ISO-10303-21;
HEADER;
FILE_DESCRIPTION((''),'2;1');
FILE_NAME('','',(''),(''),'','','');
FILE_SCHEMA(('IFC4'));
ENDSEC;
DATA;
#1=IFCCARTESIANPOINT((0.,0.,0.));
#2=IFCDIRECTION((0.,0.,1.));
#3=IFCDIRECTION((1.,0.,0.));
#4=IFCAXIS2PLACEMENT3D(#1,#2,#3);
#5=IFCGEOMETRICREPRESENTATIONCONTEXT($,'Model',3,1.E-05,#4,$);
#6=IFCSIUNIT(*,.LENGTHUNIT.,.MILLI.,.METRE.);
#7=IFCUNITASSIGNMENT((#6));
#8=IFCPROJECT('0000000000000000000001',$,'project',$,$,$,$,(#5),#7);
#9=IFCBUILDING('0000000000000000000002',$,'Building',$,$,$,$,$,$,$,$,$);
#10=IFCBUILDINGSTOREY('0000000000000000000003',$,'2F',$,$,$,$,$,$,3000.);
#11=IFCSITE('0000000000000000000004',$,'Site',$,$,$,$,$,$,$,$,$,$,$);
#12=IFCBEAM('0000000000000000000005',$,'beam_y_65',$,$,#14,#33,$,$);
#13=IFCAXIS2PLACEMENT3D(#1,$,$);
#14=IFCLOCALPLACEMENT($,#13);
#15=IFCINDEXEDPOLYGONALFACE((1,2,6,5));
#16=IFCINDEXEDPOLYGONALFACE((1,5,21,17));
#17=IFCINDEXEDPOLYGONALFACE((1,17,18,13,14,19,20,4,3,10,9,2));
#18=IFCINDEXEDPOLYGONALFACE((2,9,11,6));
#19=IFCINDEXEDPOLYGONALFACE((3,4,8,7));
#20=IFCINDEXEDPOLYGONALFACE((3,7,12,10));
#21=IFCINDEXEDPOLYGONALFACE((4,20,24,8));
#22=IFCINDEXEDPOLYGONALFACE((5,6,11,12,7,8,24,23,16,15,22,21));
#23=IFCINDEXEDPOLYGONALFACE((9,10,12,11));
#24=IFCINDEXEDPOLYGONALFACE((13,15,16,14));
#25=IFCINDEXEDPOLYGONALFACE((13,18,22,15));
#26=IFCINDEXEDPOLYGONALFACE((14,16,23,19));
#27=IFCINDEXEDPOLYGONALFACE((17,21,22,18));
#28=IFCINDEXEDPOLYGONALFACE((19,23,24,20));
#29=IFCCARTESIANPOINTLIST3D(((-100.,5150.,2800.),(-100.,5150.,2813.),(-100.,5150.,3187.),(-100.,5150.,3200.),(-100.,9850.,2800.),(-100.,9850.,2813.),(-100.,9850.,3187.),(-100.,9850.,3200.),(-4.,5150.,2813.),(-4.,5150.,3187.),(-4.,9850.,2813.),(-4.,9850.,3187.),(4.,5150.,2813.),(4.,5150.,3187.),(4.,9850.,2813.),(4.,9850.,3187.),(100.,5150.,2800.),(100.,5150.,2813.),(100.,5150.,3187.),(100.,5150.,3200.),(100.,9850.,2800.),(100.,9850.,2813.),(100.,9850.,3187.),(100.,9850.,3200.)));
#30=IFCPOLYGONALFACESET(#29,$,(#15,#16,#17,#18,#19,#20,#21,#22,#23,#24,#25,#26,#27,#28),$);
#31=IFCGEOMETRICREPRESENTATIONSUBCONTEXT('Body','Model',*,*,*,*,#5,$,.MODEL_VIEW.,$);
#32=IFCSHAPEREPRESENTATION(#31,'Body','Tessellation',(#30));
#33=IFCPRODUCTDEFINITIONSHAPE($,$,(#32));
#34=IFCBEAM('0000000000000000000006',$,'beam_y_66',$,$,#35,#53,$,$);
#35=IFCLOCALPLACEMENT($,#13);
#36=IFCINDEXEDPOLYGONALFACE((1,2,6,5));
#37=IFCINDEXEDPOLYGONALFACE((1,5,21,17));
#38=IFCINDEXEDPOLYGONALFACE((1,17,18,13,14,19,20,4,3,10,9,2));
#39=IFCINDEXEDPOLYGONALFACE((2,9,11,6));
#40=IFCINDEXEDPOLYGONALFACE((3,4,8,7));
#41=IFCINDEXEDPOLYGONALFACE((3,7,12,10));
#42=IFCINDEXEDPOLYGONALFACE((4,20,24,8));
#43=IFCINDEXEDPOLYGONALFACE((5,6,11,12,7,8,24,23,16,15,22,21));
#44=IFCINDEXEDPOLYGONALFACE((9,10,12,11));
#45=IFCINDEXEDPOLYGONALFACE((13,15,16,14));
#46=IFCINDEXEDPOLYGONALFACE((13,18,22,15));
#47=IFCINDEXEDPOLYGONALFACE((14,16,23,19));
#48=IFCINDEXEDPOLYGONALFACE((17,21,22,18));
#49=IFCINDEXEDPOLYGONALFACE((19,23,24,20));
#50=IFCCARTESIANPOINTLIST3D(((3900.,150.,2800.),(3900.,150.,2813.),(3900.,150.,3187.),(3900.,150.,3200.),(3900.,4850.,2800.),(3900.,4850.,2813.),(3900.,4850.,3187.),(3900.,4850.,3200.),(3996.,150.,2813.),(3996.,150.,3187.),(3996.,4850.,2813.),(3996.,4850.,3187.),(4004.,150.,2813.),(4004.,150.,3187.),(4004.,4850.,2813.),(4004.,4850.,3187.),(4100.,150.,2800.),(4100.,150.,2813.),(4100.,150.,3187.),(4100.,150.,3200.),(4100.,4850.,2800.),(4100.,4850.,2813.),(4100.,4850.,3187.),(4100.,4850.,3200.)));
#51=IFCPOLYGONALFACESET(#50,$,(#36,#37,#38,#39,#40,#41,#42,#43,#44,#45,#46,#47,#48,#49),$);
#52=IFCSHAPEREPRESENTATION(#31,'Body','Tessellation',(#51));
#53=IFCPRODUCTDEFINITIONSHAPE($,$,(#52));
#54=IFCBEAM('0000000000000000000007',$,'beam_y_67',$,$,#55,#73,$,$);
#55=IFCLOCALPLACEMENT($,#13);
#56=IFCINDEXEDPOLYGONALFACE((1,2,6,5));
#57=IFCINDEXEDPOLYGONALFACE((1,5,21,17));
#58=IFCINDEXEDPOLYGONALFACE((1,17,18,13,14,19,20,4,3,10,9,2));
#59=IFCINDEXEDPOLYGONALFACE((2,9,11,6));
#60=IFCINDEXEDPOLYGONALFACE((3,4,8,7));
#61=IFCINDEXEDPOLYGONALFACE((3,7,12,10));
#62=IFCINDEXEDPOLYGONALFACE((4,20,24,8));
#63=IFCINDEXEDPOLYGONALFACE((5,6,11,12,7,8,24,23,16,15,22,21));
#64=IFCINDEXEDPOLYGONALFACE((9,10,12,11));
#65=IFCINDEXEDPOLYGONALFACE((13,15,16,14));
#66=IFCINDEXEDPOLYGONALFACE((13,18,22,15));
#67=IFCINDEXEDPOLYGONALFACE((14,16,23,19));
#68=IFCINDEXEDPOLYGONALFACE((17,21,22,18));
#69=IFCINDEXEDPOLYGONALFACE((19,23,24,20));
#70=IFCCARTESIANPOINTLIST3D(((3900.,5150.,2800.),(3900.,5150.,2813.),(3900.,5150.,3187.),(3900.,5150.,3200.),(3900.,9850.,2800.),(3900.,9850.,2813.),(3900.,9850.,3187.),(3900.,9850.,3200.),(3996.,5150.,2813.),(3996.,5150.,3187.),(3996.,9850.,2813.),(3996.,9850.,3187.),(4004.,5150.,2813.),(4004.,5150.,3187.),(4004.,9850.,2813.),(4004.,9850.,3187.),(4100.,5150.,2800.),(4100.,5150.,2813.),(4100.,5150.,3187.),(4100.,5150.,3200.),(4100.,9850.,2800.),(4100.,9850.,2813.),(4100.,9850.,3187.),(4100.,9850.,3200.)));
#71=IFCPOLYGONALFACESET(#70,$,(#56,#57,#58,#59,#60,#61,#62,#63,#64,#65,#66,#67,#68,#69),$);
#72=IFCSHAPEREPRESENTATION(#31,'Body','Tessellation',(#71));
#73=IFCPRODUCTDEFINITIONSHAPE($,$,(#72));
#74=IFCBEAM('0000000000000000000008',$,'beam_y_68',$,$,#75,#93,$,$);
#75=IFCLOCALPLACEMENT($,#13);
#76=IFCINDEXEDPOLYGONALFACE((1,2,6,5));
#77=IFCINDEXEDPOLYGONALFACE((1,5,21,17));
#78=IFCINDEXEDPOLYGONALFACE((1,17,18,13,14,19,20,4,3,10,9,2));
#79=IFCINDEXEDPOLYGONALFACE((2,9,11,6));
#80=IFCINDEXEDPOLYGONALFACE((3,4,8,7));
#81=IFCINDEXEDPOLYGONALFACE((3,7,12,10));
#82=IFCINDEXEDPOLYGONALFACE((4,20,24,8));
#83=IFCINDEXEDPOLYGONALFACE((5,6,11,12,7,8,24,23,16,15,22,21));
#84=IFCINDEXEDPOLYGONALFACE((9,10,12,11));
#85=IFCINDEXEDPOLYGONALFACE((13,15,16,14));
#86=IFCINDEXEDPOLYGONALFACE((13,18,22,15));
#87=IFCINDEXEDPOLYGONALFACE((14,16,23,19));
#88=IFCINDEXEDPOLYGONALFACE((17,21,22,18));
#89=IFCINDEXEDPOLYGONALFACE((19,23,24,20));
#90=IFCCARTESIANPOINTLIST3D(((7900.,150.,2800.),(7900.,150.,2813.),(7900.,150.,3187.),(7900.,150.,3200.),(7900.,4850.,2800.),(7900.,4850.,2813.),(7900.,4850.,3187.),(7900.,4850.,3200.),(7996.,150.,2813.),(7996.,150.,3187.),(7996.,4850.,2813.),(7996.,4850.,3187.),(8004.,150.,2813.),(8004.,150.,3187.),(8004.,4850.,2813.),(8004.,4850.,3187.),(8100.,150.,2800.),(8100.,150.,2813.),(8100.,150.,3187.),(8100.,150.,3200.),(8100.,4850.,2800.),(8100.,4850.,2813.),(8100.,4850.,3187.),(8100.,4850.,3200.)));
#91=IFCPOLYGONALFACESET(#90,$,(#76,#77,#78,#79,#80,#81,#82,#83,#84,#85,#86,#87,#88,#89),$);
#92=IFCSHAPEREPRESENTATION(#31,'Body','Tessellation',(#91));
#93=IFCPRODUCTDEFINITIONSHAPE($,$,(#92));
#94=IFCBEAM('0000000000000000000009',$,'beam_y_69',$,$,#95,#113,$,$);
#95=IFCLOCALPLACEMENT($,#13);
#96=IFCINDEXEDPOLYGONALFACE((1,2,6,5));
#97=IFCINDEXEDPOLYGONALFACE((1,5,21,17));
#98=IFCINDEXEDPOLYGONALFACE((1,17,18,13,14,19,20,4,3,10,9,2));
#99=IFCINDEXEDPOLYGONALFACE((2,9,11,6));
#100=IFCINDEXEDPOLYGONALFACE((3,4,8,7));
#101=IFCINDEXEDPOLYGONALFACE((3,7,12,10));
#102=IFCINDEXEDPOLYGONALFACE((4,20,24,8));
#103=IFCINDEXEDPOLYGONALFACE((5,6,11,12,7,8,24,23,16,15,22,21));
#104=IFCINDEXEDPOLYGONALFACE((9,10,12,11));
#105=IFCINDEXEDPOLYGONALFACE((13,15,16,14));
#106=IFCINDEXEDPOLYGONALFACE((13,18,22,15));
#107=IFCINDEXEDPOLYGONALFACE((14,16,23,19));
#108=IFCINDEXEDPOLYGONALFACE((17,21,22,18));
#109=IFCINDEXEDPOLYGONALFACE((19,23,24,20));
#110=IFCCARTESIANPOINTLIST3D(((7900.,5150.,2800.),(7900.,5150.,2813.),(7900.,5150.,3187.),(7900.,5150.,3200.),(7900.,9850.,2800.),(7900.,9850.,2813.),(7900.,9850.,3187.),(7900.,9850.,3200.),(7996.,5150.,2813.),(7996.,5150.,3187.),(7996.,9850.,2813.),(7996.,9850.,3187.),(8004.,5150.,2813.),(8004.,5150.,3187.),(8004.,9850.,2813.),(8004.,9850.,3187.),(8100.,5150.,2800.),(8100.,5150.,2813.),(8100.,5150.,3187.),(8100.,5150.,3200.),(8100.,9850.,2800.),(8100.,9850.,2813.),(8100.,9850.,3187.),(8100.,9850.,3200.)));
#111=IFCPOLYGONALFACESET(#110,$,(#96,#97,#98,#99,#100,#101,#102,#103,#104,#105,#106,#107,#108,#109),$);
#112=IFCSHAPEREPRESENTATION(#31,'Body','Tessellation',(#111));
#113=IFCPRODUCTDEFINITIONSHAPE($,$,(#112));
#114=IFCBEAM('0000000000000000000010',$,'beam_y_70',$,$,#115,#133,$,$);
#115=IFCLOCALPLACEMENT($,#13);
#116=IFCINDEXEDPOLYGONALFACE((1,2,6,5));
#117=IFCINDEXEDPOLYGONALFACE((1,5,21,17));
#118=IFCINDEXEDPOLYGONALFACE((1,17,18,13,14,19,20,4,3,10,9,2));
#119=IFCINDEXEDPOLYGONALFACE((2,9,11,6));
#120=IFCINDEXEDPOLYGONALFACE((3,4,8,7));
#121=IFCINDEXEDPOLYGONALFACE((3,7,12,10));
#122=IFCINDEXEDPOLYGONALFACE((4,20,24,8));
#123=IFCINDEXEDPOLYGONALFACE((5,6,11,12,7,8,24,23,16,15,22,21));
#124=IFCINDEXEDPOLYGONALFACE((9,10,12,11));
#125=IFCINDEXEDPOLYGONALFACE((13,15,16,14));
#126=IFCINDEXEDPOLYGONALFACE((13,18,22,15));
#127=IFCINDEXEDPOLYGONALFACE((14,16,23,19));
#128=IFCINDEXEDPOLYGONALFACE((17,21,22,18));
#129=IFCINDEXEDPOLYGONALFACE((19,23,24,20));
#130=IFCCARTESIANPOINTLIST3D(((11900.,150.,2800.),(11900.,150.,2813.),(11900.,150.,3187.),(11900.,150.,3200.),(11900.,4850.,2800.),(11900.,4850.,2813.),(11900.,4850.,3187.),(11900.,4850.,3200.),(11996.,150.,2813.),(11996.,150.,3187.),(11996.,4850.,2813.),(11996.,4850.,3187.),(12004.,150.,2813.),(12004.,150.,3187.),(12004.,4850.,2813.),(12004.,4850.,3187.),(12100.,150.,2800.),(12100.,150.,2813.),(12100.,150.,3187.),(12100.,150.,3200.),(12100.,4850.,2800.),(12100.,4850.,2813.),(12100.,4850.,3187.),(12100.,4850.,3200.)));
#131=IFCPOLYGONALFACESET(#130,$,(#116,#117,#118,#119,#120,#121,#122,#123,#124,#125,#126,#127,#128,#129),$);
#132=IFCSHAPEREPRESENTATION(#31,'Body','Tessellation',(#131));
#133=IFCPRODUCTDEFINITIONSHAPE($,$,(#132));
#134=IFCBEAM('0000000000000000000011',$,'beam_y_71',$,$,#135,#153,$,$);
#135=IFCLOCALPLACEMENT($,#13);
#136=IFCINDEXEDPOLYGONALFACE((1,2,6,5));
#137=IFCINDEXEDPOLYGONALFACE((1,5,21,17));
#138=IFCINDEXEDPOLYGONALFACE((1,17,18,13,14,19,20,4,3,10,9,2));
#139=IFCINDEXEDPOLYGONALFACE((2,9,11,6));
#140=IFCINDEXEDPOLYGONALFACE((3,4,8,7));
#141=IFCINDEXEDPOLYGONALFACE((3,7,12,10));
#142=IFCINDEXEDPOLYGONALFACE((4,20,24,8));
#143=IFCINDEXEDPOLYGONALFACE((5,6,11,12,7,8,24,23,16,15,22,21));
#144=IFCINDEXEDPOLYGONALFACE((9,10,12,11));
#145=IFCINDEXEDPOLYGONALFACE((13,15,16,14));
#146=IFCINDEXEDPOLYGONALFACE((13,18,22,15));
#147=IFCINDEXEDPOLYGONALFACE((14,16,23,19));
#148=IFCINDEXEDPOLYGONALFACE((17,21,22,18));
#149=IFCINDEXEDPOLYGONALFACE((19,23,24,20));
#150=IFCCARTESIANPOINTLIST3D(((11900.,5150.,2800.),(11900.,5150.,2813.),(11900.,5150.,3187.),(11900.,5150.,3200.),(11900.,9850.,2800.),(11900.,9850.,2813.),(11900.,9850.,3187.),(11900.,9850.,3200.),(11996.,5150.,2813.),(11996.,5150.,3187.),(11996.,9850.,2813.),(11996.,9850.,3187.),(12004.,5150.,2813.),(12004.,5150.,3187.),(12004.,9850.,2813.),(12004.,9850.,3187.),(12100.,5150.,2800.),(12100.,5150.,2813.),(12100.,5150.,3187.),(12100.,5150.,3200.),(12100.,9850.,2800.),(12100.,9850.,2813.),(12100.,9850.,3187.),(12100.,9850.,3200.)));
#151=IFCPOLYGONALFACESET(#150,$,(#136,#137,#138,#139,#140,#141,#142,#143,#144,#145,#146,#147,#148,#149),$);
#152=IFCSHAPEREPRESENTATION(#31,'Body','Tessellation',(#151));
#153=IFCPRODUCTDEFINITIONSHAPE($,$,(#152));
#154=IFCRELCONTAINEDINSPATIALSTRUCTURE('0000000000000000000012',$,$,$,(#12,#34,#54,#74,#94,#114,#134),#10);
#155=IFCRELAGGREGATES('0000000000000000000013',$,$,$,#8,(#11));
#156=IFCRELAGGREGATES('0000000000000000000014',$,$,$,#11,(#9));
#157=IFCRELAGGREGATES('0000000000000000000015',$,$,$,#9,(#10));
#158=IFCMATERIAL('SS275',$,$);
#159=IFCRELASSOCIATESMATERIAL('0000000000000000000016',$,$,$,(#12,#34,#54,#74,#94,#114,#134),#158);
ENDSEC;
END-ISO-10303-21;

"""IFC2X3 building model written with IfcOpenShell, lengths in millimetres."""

from ifc_helpers import new_model, si_unit, frame, origin, origin_with_axes, origin_2d_with_axis, place, context, subcontext, project, spatial, i_section, extrude, material, element, save


model = new_model("IFC2X3")

# Units and contexts
model_context = context("Model", 3, precision=1e-05, world=origin_with_axes())
body_context = subcontext(model_context, "Body", "Model", "MODEL_VIEW")
ifc_project = project(units=[si_unit("LENGTHUNIT", "METRE", prefix="MILLI")], contexts=[model_context])

# Site, building, storey
site = spatial("IfcSite", under=ifc_project, Name="Site")
building = spatial("IfcBuilding", under=site, Name="Building")
storey = spatial("IfcBuildingStorey", under=building, Name="2F", Elevation=3000.0)

# Shared definitions
ifc_material = material(Name="SS275")

# Beams
for number, where, z_axis, x_axis, name in (
    (1, (0.0, 5150.0, 3000.0), (0.0, 1.0, 0.0), (-1.0, 0.0, 0.0), "beam_y_65"),
    (2, (4000.0, 150.0, 3000.0), (0.0, 1.0, 0.0), (-1.0, 0.0, 0.0), "beam_y_66"),
    (3, (4000.0, 5150.0, 3000.0), (0.0, 1.0, 0.0), (-1.0, 0.0, 0.0), "beam_y_67"),
    (4, (8000.0, 150.0, 3000.0), (0.0, 1.0, 0.0), (-1.0, 0.0, 0.0), "beam_y_68"),
    (5, (8000.0, 5150.0, 3000.0), (0.0, 1.0, 0.0), (-1.0, 0.0, 0.0), "beam_y_69"),
    (6, (12000.0, 150.0, 3000.0), (0.0, 1.0, 0.0), (-1.0, 0.0, 0.0), "beam_y_70"),
    (7, (12000.0, 5150.0, 3000.0), (0.0, 1.0, 0.0), (-1.0, 0.0, 0.0), "beam_y_71"),
):
    element("IfcBeam", number, at=place(None, frame(where, z_axis=z_axis, x_axis=x_axis)), inside=storey, material=ifc_material, Name=name, context=body_context, shape_type="SweptSolid", body=[
        extrude(i_section(OverallWidth=200.0, OverallDepth=400.0, WebThickness=8.0, FlangeThickness=13.0, at=origin_2d_with_axis()), origin(), (0.0, 0.0, 1.0), 4700.0),
    ])

save(model, "model.ifc")
